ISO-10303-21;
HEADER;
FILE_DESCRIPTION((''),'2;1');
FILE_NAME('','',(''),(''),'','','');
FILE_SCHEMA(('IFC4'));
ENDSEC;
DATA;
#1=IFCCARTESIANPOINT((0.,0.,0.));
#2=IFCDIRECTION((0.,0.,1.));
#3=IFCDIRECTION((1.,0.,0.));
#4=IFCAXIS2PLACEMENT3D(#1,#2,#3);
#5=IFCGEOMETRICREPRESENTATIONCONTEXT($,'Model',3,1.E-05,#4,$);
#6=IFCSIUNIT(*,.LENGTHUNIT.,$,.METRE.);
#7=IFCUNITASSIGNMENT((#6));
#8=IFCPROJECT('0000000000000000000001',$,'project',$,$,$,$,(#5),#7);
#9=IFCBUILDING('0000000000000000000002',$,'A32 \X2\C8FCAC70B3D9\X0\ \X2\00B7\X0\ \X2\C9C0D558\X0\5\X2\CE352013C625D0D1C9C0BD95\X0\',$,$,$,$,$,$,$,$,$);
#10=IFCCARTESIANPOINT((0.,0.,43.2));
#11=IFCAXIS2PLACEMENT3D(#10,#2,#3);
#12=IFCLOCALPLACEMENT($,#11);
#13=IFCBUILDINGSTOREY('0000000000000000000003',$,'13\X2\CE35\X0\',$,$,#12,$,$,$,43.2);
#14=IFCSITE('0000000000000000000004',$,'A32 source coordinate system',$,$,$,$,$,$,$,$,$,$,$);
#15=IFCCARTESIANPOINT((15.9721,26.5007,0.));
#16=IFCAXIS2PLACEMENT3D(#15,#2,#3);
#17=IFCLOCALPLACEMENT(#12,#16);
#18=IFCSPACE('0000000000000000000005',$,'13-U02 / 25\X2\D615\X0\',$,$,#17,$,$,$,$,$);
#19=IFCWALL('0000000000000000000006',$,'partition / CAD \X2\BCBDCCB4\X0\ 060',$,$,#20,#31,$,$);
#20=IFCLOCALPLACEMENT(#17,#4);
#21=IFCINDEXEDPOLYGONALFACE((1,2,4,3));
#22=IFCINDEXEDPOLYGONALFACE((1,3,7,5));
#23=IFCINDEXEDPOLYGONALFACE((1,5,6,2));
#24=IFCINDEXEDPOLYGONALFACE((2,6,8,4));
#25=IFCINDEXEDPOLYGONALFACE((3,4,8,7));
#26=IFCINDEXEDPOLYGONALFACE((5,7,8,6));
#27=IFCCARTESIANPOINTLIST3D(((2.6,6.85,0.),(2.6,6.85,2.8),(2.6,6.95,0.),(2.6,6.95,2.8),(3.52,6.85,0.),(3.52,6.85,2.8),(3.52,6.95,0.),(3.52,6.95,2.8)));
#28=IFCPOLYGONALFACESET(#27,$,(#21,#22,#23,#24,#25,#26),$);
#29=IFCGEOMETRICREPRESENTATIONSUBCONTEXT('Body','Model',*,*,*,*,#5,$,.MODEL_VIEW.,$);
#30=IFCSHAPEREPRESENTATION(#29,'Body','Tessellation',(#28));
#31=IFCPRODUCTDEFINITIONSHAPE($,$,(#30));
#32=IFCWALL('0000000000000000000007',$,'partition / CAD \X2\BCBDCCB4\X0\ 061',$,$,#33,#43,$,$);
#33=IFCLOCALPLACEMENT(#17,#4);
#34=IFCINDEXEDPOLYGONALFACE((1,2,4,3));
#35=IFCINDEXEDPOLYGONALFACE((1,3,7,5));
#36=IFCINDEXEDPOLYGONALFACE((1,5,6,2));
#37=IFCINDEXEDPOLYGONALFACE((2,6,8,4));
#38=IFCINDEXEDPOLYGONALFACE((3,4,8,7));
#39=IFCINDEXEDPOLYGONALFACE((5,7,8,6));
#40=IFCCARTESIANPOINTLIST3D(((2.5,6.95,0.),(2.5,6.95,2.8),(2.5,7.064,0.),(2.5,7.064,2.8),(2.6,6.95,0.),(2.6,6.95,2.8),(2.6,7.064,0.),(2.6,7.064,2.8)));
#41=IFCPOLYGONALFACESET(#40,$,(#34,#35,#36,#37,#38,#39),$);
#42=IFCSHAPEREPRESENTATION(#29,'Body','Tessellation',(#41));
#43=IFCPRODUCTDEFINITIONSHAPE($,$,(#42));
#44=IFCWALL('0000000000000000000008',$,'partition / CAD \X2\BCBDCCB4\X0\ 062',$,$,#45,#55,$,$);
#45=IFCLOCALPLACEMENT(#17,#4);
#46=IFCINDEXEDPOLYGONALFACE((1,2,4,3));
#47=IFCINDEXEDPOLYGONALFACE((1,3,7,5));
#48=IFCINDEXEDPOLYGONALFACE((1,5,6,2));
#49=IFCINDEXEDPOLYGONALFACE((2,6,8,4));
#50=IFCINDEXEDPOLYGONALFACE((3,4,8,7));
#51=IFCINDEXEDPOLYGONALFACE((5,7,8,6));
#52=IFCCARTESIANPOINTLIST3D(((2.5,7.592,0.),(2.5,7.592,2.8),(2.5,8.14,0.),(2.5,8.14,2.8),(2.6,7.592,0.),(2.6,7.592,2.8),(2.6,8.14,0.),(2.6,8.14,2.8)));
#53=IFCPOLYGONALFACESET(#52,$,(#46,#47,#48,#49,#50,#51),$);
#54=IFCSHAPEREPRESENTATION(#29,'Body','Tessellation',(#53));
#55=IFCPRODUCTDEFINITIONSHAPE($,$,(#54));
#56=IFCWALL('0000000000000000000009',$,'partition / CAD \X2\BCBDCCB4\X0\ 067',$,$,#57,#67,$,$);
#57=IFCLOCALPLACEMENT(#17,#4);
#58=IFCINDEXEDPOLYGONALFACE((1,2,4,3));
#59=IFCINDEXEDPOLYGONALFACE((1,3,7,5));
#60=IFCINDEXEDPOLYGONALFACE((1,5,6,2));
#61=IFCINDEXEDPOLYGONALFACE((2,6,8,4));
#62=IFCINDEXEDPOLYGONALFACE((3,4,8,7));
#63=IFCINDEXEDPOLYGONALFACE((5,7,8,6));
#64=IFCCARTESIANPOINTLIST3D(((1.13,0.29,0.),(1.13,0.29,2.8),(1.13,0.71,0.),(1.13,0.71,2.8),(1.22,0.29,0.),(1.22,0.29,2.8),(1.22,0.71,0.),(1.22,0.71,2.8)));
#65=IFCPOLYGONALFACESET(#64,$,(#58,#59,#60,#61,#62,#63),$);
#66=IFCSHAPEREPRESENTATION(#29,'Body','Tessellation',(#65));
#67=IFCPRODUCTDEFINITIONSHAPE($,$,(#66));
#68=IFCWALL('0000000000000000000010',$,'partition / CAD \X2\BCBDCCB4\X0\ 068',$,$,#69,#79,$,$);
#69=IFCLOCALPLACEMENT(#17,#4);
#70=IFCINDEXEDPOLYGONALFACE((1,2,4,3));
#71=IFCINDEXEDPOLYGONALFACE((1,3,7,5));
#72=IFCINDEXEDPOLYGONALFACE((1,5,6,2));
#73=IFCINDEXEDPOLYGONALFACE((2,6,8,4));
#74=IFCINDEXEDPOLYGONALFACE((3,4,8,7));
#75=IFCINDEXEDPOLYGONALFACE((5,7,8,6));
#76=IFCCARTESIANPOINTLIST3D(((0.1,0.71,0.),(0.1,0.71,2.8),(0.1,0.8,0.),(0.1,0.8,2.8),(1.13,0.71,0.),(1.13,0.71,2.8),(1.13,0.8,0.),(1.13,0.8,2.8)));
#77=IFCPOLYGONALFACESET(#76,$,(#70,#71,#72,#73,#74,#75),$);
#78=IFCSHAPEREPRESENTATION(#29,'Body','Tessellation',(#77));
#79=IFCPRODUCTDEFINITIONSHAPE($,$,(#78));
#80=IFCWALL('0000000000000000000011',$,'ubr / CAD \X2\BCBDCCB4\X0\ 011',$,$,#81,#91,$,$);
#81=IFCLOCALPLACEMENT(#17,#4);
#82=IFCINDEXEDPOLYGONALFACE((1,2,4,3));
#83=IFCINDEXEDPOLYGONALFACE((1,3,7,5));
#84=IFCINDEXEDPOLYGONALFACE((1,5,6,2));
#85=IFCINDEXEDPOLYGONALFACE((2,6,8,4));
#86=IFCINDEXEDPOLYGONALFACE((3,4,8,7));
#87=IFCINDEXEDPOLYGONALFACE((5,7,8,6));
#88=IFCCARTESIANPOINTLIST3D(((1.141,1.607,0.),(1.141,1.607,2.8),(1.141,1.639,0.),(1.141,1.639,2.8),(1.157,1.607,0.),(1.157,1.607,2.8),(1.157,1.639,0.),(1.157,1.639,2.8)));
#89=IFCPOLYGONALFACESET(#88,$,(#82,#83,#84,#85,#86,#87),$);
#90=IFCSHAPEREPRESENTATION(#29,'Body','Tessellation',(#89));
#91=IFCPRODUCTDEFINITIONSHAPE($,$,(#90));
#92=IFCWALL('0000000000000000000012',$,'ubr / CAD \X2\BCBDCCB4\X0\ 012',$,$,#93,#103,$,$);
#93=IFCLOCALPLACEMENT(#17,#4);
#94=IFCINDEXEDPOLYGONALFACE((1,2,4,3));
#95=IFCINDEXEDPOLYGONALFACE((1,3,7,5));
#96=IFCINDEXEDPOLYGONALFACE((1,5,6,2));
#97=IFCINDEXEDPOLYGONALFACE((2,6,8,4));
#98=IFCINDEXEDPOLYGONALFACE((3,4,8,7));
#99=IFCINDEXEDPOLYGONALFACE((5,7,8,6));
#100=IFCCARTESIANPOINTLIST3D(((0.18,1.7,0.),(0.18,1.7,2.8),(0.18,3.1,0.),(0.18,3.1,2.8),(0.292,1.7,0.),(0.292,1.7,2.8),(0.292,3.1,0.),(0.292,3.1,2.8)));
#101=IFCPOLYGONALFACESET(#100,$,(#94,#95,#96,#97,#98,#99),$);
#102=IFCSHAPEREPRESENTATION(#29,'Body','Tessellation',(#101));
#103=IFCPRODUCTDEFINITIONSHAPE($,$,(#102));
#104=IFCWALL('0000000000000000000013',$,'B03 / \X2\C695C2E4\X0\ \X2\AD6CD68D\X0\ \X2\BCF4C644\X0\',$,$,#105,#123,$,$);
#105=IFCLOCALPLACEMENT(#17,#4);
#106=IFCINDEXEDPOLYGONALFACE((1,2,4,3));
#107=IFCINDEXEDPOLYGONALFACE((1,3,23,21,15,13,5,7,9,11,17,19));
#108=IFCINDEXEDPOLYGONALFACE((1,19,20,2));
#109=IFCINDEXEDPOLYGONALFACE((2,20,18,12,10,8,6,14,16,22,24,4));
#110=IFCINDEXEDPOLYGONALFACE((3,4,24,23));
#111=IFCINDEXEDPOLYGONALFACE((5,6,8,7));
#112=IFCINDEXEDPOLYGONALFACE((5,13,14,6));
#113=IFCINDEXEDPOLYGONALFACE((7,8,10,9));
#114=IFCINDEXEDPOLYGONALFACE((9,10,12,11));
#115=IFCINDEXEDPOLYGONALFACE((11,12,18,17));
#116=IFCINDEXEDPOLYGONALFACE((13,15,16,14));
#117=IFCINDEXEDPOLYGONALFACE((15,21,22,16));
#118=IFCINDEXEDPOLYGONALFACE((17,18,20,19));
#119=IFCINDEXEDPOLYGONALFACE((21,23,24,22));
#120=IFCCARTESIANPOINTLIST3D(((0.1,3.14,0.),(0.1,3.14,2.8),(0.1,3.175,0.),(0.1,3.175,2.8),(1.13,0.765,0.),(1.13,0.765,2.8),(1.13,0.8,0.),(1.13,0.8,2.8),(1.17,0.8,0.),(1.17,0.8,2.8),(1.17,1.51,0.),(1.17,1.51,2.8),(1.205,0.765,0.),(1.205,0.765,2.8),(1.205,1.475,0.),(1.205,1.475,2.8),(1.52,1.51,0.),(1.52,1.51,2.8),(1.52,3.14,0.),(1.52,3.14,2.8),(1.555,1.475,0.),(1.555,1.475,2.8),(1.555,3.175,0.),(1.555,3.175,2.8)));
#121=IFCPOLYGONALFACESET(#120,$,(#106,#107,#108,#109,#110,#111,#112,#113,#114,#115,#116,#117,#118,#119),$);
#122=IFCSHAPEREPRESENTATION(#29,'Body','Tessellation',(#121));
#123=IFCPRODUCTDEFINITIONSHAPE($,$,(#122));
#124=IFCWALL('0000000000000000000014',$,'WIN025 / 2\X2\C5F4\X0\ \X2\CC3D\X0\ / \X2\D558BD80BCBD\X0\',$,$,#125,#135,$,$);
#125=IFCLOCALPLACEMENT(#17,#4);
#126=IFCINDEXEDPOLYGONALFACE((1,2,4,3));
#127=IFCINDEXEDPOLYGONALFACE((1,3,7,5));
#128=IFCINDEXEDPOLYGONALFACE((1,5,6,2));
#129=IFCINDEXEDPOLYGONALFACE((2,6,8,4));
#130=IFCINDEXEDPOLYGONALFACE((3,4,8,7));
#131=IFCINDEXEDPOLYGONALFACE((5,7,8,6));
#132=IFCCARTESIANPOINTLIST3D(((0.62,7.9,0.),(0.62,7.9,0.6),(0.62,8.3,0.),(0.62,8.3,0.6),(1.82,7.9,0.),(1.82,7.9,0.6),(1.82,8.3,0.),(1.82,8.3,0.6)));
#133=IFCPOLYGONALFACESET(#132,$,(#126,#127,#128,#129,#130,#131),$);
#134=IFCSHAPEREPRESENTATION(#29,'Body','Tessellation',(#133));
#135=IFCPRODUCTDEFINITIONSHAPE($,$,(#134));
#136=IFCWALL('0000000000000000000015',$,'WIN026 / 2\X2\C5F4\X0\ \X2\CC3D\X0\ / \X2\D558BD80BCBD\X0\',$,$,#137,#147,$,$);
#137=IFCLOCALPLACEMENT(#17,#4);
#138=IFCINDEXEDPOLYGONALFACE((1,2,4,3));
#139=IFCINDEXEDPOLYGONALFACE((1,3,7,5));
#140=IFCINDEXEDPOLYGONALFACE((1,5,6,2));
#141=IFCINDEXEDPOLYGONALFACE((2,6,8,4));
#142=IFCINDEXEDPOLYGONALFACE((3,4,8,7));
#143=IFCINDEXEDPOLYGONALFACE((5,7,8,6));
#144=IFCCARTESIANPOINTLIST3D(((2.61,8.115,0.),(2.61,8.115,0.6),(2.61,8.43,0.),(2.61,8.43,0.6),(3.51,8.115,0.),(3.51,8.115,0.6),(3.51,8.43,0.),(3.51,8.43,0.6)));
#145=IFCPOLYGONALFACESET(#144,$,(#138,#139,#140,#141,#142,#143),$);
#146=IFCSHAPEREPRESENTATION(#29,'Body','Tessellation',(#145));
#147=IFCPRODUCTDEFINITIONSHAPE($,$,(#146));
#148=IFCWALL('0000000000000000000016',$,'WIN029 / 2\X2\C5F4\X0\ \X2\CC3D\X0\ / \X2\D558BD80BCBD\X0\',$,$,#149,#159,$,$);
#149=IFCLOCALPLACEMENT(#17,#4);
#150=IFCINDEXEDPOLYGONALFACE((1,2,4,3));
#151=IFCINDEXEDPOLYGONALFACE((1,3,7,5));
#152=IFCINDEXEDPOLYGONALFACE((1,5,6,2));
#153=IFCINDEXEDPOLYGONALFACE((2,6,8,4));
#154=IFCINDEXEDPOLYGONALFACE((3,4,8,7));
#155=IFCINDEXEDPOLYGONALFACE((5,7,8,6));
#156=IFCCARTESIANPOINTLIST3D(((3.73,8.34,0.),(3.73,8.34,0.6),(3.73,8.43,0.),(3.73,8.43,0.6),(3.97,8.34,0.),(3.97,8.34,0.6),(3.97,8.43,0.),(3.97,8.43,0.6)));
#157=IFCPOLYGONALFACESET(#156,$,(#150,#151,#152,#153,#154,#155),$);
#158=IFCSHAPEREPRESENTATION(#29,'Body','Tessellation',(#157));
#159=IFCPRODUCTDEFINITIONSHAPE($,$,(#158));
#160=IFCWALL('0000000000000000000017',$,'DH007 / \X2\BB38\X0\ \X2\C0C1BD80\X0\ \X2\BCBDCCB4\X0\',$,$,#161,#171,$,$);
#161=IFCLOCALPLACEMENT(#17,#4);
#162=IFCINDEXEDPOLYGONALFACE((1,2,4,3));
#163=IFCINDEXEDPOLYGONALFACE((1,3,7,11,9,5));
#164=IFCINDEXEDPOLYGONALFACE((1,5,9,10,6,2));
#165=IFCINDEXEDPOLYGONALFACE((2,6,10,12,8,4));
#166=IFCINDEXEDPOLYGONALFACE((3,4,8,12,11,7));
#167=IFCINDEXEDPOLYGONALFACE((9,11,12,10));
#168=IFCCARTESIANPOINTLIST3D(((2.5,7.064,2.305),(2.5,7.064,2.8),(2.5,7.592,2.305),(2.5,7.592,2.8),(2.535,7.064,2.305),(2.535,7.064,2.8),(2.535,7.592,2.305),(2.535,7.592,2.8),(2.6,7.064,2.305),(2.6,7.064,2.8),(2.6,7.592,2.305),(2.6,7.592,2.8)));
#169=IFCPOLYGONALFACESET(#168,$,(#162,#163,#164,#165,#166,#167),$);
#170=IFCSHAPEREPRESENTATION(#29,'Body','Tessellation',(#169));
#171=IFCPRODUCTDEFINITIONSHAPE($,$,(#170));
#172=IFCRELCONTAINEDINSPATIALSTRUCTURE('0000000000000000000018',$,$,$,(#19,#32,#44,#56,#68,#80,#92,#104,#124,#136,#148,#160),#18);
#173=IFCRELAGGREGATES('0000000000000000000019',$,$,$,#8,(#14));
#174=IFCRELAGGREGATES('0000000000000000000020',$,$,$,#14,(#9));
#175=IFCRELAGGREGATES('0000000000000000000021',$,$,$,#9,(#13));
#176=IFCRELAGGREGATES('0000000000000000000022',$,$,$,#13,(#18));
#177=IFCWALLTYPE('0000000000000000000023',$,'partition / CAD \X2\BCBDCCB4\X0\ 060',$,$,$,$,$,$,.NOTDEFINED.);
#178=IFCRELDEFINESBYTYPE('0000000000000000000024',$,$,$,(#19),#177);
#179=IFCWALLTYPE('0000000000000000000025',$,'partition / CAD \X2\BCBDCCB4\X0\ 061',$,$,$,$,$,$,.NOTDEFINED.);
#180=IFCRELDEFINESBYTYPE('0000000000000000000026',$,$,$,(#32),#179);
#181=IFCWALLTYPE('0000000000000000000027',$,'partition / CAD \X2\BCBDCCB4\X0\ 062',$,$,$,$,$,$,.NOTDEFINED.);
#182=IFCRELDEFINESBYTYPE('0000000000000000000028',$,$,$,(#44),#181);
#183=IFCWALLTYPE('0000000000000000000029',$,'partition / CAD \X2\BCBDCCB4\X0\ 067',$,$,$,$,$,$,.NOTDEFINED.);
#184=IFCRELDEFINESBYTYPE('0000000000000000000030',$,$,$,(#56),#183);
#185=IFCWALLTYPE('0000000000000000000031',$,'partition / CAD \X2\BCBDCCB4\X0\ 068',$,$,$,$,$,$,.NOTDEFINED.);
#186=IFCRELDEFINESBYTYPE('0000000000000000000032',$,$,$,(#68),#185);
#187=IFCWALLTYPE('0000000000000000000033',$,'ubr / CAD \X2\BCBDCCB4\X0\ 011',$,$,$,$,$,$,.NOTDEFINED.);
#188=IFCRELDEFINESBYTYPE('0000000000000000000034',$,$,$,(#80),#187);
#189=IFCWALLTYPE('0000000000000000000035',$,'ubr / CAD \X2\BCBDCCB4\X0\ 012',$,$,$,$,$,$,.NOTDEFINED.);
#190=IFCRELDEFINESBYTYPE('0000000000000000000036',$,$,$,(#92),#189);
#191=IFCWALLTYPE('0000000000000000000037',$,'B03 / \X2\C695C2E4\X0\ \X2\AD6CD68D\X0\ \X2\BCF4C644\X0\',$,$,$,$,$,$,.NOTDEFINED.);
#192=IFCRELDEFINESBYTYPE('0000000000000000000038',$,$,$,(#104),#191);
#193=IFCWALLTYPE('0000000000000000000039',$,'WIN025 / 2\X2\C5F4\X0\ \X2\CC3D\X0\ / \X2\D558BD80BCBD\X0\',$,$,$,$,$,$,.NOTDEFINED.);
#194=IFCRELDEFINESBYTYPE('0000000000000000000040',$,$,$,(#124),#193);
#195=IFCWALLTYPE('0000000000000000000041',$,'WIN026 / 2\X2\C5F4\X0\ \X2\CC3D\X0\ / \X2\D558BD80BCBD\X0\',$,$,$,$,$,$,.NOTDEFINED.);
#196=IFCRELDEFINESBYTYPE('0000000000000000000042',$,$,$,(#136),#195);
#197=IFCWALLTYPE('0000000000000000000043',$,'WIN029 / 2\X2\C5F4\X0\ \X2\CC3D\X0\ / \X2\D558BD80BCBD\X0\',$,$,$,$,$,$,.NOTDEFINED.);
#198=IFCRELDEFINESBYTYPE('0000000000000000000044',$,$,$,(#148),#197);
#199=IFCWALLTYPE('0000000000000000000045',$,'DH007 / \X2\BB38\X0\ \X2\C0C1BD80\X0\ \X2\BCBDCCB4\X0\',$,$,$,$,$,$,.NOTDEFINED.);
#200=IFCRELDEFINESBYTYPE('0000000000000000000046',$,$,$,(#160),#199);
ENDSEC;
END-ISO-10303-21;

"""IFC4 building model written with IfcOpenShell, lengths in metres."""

from ifc_helpers import new_model, si_unit, frame, origin, origin_with_axes, place, context, subcontext, project, spatial, polyline, outline, extrude, source, transform, mapped, type_object, type_shapes, element, save


model = new_model("IFC4")

# Units and contexts
model_context = context("Model", 3, precision=1e-05, world=origin_with_axes())
body_context = subcontext(model_context, "Body", "Model", "MODEL_VIEW")
ifc_project = project(units=[si_unit("LENGTHUNIT", "METRE")], contexts=[model_context])

# Site, building, storey, space
site = spatial("IfcSite", under=ifc_project, Name="A32 source coordinate system")
building = spatial("IfcBuilding", under=site, Name="A32 주거동 · 지하5층–옥탑지붕")
storey_placement = place(None, frame((0.0, 0.0, 43.2), z_axis=(0.0, 0.0, 1.0), x_axis=(1.0, 0.0, 0.0)))
storey = spatial("IfcBuildingStorey", under=building, at=storey_placement, Name="13층", Elevation=43.2)
space_1_placement = place(storey_placement, frame((15.9721, 26.5007, 0.0), z_axis=(0.0, 0.0, 1.0), x_axis=(1.0, 0.0, 0.0)))
space_1 = spatial("IfcSpace", under=storey, at=space_1_placement, Name="13-U02 / 25형")

# Walls
wall_type_1 = type_object("IfcWallType", Name="partition / CAD 벽체 060", PredefinedType="NOTDEFINED")
shared_shape_1 = source(origin(), body_context, "Body", "SweptSolid", [
    extrude(outline(polyline([(3.52, 6.85), (2.6, 6.85), (2.6, 6.95), (3.52, 6.95), (3.52, 6.85)])), origin(), (0.0, 0.0, 1.0), 2.8),
])
type_shapes(wall_type_1, [shared_shape_1])
wall_1_placement = place(space_1_placement, origin_with_axes())
element("IfcWall", 1, at=wall_1_placement, inside=space_1, type_object=wall_type_1, Name="partition / CAD 벽체 060", context=body_context, shape_type="MappedRepresentation", body=[
    mapped(shared_shape_1, transform((0.0, 0.0, 0.0), scale=1.0)),
])
wall_type_2 = type_object("IfcWallType", Name="partition / CAD 벽체 061", PredefinedType="NOTDEFINED")
shared_shape_2 = source(origin(), body_context, "Body", "SweptSolid", [
    extrude(outline(polyline([(2.6, 7.064), (2.6, 6.95), (2.5, 6.95), (2.5, 7.064), (2.6, 7.064)])), origin(), (0.0, 0.0, 1.0), 2.8),
])
type_shapes(wall_type_2, [shared_shape_2])
wall_2_placement = place(space_1_placement, origin_with_axes())
element("IfcWall", 2, at=wall_2_placement, inside=space_1, type_object=wall_type_2, Name="partition / CAD 벽체 061", context=body_context, shape_type="MappedRepresentation", body=[
    mapped(shared_shape_2, transform((0.0, 0.0, 0.0), scale=1.0)),
])
wall_type_3 = type_object("IfcWallType", Name="partition / CAD 벽체 062", PredefinedType="NOTDEFINED")
shared_shape_3 = source(origin(), body_context, "Body", "SweptSolid", [
    extrude(outline(polyline([(2.5, 7.592), (2.5, 8.14), (2.6, 8.14), (2.6, 7.592), (2.5, 7.592)])), origin(), (0.0, 0.0, 1.0), 2.8),
])
type_shapes(wall_type_3, [shared_shape_3])
wall_3_placement = place(space_1_placement, origin_with_axes())
element("IfcWall", 3, at=wall_3_placement, inside=space_1, type_object=wall_type_3, Name="partition / CAD 벽체 062", context=body_context, shape_type="MappedRepresentation", body=[
    mapped(shared_shape_3, transform((0.0, 0.0, 0.0), scale=1.0)),
])
wall_type_4 = type_object("IfcWallType", Name="partition / CAD 벽체 067", PredefinedType="NOTDEFINED")
shared_shape_4 = source(origin(), body_context, "Body", "SweptSolid", [
    extrude(outline(polyline([(1.22, 0.71), (1.22, 0.29), (1.13, 0.29), (1.13, 0.71), (1.22, 0.71)])), origin(), (0.0, 0.0, 1.0), 2.8),
])
type_shapes(wall_type_4, [shared_shape_4])
wall_4_placement = place(space_1_placement, origin_with_axes())
element("IfcWall", 4, at=wall_4_placement, inside=space_1, type_object=wall_type_4, Name="partition / CAD 벽체 067", context=body_context, shape_type="MappedRepresentation", body=[
    mapped(shared_shape_4, transform((0.0, 0.0, 0.0), scale=1.0)),
])
wall_type_5 = type_object("IfcWallType", Name="partition / CAD 벽체 068", PredefinedType="NOTDEFINED")
shared_shape_5 = source(origin(), body_context, "Body", "SweptSolid", [
    extrude(outline(polyline([(1.13, 0.8), (1.13, 0.71), (0.1, 0.71), (0.1, 0.8), (1.13, 0.8)])), origin(), (0.0, 0.0, 1.0), 2.8),
])
type_shapes(wall_type_5, [shared_shape_5])
wall_5_placement = place(space_1_placement, origin_with_axes())
element("IfcWall", 5, at=wall_5_placement, inside=space_1, type_object=wall_type_5, Name="partition / CAD 벽체 068", context=body_context, shape_type="MappedRepresentation", body=[
    mapped(shared_shape_5, transform((0.0, 0.0, 0.0), scale=1.0)),
])
wall_type_6 = type_object("IfcWallType", Name="ubr / CAD 벽체 011", PredefinedType="NOTDEFINED")
shared_shape_6 = source(origin(), body_context, "Body", "SweptSolid", [
    extrude(outline(polyline([(1.141, 1.607), (1.141, 1.639), (1.157, 1.639), (1.157, 1.607), (1.141, 1.607)])), origin(), (0.0, 0.0, 1.0), 2.8),
])
type_shapes(wall_type_6, [shared_shape_6])
wall_6_placement = place(space_1_placement, origin_with_axes())
element("IfcWall", 6, at=wall_6_placement, inside=space_1, type_object=wall_type_6, Name="ubr / CAD 벽체 011", context=body_context, shape_type="MappedRepresentation", body=[
    mapped(shared_shape_6, transform((0.0, 0.0, 0.0), scale=1.0)),
])
wall_type_7 = type_object("IfcWallType", Name="ubr / CAD 벽체 012", PredefinedType="NOTDEFINED")
shared_shape_7 = source(origin(), body_context, "Body", "SweptSolid", [
    extrude(outline(polyline([(0.18, 1.7), (0.18, 3.1), (0.292, 3.1), (0.292, 1.7), (0.18, 1.7)])), origin(), (0.0, 0.0, 1.0), 2.8),
])
type_shapes(wall_type_7, [shared_shape_7])
wall_7_placement = place(space_1_placement, origin_with_axes())
element("IfcWall", 7, at=wall_7_placement, inside=space_1, type_object=wall_type_7, Name="ubr / CAD 벽체 012", context=body_context, shape_type="MappedRepresentation", body=[
    mapped(shared_shape_7, transform((0.0, 0.0, 0.0), scale=1.0)),
])
wall_type_8 = type_object("IfcWallType", Name="B03 / 욕실 구획 보완", PredefinedType="NOTDEFINED")
shared_shape_8 = source(origin(), body_context, "Body", "SweptSolid", [
    extrude(outline(polyline([(1.13, 0.765), (1.13, 0.8), (1.17, 0.8), (1.17, 1.51), (1.52, 1.51), (1.52, 3.14), (0.1, 3.14), (0.1, 3.175), (1.555, 3.175), (1.555, 1.475), (1.205, 1.475), (1.205, 0.765), (1.13, 0.765)])), origin(), (0.0, 0.0, 1.0), 2.8),
])
type_shapes(wall_type_8, [shared_shape_8])
wall_8_placement = place(space_1_placement, origin_with_axes())
element("IfcWall", 8, at=wall_8_placement, inside=space_1, type_object=wall_type_8, Name="B03 / 욕실 구획 보완", context=body_context, shape_type="MappedRepresentation", body=[
    mapped(shared_shape_8, transform((0.0, 0.0, 0.0), scale=1.0)),
])
wall_type_9 = type_object("IfcWallType", Name="WIN025 / 2열 창 / 하부벽", PredefinedType="NOTDEFINED")
shared_shape_9 = source(origin(), body_context, "Body", "SweptSolid", [
    extrude(outline(polyline([(1.82, 8.3), (1.82, 7.9), (0.62, 7.9), (0.62, 8.3), (1.82, 8.3)])), origin(), (0.0, 0.0, 1.0), 0.6),
])
type_shapes(wall_type_9, [shared_shape_9])
wall_9_placement = place(space_1_placement, origin_with_axes())
element("IfcWall", 9, at=wall_9_placement, inside=space_1, type_object=wall_type_9, Name="WIN025 / 2열 창 / 하부벽", context=body_context, shape_type="MappedRepresentation", body=[
    mapped(shared_shape_9, transform((0.0, 0.0, 0.0), scale=1.0)),
])
wall_type_10 = type_object("IfcWallType", Name="WIN026 / 2열 창 / 하부벽", PredefinedType="NOTDEFINED")
shared_shape_10 = source(origin(), body_context, "Body", "SweptSolid", [
    extrude(outline(polyline([(3.51, 8.43), (3.51, 8.115), (2.61, 8.115), (2.61, 8.43), (3.51, 8.43)])), origin(), (0.0, 0.0, 1.0), 0.6),
])
type_shapes(wall_type_10, [shared_shape_10])
wall_10_placement = place(space_1_placement, origin_with_axes())
element("IfcWall", 10, at=wall_10_placement, inside=space_1, type_object=wall_type_10, Name="WIN026 / 2열 창 / 하부벽", context=body_context, shape_type="MappedRepresentation", body=[
    mapped(shared_shape_10, transform((0.0, 0.0, 0.0), scale=1.0)),
])
wall_type_11 = type_object("IfcWallType", Name="WIN029 / 2열 창 / 하부벽", PredefinedType="NOTDEFINED")
shared_shape_11 = source(origin(), body_context, "Body", "SweptSolid", [
    extrude(outline(polyline([(3.97, 8.43), (3.97, 8.34), (3.73, 8.34), (3.73, 8.43), (3.97, 8.43)])), origin(), (0.0, 0.0, 1.0), 0.6),
])
type_shapes(wall_type_11, [shared_shape_11])
wall_11_placement = place(space_1_placement, origin_with_axes())
element("IfcWall", 11, at=wall_11_placement, inside=space_1, type_object=wall_type_11, Name="WIN029 / 2열 창 / 하부벽", context=body_context, shape_type="MappedRepresentation", body=[
    mapped(shared_shape_11, transform((0.0, 0.0, 0.0), scale=1.0)),
])
wall_type_12 = type_object("IfcWallType", Name="DH007 / 문 상부 벽체", PredefinedType="NOTDEFINED")
shared_shape_12 = source(origin(), body_context, "Body", "SweptSolid", [
    extrude(outline(polyline([(2.5, 7.592), (2.535, 7.592), (2.6, 7.592), (2.6, 7.064), (2.535, 7.064), (2.5, 7.064), (2.5, 7.592)])), frame((0.0, 0.0, 2.305)), (0.0, 0.0, 1.0), 0.495),
])
type_shapes(wall_type_12, [shared_shape_12])
wall_12_placement = place(space_1_placement, origin_with_axes())
element("IfcWall", 12, at=wall_12_placement, inside=space_1, type_object=wall_type_12, Name="DH007 / 문 상부 벽체", context=body_context, shape_type="MappedRepresentation", body=[
    mapped(shared_shape_12, transform((0.0, 0.0, 0.0), scale=1.0)),
])

save(model, "model.ifc")
